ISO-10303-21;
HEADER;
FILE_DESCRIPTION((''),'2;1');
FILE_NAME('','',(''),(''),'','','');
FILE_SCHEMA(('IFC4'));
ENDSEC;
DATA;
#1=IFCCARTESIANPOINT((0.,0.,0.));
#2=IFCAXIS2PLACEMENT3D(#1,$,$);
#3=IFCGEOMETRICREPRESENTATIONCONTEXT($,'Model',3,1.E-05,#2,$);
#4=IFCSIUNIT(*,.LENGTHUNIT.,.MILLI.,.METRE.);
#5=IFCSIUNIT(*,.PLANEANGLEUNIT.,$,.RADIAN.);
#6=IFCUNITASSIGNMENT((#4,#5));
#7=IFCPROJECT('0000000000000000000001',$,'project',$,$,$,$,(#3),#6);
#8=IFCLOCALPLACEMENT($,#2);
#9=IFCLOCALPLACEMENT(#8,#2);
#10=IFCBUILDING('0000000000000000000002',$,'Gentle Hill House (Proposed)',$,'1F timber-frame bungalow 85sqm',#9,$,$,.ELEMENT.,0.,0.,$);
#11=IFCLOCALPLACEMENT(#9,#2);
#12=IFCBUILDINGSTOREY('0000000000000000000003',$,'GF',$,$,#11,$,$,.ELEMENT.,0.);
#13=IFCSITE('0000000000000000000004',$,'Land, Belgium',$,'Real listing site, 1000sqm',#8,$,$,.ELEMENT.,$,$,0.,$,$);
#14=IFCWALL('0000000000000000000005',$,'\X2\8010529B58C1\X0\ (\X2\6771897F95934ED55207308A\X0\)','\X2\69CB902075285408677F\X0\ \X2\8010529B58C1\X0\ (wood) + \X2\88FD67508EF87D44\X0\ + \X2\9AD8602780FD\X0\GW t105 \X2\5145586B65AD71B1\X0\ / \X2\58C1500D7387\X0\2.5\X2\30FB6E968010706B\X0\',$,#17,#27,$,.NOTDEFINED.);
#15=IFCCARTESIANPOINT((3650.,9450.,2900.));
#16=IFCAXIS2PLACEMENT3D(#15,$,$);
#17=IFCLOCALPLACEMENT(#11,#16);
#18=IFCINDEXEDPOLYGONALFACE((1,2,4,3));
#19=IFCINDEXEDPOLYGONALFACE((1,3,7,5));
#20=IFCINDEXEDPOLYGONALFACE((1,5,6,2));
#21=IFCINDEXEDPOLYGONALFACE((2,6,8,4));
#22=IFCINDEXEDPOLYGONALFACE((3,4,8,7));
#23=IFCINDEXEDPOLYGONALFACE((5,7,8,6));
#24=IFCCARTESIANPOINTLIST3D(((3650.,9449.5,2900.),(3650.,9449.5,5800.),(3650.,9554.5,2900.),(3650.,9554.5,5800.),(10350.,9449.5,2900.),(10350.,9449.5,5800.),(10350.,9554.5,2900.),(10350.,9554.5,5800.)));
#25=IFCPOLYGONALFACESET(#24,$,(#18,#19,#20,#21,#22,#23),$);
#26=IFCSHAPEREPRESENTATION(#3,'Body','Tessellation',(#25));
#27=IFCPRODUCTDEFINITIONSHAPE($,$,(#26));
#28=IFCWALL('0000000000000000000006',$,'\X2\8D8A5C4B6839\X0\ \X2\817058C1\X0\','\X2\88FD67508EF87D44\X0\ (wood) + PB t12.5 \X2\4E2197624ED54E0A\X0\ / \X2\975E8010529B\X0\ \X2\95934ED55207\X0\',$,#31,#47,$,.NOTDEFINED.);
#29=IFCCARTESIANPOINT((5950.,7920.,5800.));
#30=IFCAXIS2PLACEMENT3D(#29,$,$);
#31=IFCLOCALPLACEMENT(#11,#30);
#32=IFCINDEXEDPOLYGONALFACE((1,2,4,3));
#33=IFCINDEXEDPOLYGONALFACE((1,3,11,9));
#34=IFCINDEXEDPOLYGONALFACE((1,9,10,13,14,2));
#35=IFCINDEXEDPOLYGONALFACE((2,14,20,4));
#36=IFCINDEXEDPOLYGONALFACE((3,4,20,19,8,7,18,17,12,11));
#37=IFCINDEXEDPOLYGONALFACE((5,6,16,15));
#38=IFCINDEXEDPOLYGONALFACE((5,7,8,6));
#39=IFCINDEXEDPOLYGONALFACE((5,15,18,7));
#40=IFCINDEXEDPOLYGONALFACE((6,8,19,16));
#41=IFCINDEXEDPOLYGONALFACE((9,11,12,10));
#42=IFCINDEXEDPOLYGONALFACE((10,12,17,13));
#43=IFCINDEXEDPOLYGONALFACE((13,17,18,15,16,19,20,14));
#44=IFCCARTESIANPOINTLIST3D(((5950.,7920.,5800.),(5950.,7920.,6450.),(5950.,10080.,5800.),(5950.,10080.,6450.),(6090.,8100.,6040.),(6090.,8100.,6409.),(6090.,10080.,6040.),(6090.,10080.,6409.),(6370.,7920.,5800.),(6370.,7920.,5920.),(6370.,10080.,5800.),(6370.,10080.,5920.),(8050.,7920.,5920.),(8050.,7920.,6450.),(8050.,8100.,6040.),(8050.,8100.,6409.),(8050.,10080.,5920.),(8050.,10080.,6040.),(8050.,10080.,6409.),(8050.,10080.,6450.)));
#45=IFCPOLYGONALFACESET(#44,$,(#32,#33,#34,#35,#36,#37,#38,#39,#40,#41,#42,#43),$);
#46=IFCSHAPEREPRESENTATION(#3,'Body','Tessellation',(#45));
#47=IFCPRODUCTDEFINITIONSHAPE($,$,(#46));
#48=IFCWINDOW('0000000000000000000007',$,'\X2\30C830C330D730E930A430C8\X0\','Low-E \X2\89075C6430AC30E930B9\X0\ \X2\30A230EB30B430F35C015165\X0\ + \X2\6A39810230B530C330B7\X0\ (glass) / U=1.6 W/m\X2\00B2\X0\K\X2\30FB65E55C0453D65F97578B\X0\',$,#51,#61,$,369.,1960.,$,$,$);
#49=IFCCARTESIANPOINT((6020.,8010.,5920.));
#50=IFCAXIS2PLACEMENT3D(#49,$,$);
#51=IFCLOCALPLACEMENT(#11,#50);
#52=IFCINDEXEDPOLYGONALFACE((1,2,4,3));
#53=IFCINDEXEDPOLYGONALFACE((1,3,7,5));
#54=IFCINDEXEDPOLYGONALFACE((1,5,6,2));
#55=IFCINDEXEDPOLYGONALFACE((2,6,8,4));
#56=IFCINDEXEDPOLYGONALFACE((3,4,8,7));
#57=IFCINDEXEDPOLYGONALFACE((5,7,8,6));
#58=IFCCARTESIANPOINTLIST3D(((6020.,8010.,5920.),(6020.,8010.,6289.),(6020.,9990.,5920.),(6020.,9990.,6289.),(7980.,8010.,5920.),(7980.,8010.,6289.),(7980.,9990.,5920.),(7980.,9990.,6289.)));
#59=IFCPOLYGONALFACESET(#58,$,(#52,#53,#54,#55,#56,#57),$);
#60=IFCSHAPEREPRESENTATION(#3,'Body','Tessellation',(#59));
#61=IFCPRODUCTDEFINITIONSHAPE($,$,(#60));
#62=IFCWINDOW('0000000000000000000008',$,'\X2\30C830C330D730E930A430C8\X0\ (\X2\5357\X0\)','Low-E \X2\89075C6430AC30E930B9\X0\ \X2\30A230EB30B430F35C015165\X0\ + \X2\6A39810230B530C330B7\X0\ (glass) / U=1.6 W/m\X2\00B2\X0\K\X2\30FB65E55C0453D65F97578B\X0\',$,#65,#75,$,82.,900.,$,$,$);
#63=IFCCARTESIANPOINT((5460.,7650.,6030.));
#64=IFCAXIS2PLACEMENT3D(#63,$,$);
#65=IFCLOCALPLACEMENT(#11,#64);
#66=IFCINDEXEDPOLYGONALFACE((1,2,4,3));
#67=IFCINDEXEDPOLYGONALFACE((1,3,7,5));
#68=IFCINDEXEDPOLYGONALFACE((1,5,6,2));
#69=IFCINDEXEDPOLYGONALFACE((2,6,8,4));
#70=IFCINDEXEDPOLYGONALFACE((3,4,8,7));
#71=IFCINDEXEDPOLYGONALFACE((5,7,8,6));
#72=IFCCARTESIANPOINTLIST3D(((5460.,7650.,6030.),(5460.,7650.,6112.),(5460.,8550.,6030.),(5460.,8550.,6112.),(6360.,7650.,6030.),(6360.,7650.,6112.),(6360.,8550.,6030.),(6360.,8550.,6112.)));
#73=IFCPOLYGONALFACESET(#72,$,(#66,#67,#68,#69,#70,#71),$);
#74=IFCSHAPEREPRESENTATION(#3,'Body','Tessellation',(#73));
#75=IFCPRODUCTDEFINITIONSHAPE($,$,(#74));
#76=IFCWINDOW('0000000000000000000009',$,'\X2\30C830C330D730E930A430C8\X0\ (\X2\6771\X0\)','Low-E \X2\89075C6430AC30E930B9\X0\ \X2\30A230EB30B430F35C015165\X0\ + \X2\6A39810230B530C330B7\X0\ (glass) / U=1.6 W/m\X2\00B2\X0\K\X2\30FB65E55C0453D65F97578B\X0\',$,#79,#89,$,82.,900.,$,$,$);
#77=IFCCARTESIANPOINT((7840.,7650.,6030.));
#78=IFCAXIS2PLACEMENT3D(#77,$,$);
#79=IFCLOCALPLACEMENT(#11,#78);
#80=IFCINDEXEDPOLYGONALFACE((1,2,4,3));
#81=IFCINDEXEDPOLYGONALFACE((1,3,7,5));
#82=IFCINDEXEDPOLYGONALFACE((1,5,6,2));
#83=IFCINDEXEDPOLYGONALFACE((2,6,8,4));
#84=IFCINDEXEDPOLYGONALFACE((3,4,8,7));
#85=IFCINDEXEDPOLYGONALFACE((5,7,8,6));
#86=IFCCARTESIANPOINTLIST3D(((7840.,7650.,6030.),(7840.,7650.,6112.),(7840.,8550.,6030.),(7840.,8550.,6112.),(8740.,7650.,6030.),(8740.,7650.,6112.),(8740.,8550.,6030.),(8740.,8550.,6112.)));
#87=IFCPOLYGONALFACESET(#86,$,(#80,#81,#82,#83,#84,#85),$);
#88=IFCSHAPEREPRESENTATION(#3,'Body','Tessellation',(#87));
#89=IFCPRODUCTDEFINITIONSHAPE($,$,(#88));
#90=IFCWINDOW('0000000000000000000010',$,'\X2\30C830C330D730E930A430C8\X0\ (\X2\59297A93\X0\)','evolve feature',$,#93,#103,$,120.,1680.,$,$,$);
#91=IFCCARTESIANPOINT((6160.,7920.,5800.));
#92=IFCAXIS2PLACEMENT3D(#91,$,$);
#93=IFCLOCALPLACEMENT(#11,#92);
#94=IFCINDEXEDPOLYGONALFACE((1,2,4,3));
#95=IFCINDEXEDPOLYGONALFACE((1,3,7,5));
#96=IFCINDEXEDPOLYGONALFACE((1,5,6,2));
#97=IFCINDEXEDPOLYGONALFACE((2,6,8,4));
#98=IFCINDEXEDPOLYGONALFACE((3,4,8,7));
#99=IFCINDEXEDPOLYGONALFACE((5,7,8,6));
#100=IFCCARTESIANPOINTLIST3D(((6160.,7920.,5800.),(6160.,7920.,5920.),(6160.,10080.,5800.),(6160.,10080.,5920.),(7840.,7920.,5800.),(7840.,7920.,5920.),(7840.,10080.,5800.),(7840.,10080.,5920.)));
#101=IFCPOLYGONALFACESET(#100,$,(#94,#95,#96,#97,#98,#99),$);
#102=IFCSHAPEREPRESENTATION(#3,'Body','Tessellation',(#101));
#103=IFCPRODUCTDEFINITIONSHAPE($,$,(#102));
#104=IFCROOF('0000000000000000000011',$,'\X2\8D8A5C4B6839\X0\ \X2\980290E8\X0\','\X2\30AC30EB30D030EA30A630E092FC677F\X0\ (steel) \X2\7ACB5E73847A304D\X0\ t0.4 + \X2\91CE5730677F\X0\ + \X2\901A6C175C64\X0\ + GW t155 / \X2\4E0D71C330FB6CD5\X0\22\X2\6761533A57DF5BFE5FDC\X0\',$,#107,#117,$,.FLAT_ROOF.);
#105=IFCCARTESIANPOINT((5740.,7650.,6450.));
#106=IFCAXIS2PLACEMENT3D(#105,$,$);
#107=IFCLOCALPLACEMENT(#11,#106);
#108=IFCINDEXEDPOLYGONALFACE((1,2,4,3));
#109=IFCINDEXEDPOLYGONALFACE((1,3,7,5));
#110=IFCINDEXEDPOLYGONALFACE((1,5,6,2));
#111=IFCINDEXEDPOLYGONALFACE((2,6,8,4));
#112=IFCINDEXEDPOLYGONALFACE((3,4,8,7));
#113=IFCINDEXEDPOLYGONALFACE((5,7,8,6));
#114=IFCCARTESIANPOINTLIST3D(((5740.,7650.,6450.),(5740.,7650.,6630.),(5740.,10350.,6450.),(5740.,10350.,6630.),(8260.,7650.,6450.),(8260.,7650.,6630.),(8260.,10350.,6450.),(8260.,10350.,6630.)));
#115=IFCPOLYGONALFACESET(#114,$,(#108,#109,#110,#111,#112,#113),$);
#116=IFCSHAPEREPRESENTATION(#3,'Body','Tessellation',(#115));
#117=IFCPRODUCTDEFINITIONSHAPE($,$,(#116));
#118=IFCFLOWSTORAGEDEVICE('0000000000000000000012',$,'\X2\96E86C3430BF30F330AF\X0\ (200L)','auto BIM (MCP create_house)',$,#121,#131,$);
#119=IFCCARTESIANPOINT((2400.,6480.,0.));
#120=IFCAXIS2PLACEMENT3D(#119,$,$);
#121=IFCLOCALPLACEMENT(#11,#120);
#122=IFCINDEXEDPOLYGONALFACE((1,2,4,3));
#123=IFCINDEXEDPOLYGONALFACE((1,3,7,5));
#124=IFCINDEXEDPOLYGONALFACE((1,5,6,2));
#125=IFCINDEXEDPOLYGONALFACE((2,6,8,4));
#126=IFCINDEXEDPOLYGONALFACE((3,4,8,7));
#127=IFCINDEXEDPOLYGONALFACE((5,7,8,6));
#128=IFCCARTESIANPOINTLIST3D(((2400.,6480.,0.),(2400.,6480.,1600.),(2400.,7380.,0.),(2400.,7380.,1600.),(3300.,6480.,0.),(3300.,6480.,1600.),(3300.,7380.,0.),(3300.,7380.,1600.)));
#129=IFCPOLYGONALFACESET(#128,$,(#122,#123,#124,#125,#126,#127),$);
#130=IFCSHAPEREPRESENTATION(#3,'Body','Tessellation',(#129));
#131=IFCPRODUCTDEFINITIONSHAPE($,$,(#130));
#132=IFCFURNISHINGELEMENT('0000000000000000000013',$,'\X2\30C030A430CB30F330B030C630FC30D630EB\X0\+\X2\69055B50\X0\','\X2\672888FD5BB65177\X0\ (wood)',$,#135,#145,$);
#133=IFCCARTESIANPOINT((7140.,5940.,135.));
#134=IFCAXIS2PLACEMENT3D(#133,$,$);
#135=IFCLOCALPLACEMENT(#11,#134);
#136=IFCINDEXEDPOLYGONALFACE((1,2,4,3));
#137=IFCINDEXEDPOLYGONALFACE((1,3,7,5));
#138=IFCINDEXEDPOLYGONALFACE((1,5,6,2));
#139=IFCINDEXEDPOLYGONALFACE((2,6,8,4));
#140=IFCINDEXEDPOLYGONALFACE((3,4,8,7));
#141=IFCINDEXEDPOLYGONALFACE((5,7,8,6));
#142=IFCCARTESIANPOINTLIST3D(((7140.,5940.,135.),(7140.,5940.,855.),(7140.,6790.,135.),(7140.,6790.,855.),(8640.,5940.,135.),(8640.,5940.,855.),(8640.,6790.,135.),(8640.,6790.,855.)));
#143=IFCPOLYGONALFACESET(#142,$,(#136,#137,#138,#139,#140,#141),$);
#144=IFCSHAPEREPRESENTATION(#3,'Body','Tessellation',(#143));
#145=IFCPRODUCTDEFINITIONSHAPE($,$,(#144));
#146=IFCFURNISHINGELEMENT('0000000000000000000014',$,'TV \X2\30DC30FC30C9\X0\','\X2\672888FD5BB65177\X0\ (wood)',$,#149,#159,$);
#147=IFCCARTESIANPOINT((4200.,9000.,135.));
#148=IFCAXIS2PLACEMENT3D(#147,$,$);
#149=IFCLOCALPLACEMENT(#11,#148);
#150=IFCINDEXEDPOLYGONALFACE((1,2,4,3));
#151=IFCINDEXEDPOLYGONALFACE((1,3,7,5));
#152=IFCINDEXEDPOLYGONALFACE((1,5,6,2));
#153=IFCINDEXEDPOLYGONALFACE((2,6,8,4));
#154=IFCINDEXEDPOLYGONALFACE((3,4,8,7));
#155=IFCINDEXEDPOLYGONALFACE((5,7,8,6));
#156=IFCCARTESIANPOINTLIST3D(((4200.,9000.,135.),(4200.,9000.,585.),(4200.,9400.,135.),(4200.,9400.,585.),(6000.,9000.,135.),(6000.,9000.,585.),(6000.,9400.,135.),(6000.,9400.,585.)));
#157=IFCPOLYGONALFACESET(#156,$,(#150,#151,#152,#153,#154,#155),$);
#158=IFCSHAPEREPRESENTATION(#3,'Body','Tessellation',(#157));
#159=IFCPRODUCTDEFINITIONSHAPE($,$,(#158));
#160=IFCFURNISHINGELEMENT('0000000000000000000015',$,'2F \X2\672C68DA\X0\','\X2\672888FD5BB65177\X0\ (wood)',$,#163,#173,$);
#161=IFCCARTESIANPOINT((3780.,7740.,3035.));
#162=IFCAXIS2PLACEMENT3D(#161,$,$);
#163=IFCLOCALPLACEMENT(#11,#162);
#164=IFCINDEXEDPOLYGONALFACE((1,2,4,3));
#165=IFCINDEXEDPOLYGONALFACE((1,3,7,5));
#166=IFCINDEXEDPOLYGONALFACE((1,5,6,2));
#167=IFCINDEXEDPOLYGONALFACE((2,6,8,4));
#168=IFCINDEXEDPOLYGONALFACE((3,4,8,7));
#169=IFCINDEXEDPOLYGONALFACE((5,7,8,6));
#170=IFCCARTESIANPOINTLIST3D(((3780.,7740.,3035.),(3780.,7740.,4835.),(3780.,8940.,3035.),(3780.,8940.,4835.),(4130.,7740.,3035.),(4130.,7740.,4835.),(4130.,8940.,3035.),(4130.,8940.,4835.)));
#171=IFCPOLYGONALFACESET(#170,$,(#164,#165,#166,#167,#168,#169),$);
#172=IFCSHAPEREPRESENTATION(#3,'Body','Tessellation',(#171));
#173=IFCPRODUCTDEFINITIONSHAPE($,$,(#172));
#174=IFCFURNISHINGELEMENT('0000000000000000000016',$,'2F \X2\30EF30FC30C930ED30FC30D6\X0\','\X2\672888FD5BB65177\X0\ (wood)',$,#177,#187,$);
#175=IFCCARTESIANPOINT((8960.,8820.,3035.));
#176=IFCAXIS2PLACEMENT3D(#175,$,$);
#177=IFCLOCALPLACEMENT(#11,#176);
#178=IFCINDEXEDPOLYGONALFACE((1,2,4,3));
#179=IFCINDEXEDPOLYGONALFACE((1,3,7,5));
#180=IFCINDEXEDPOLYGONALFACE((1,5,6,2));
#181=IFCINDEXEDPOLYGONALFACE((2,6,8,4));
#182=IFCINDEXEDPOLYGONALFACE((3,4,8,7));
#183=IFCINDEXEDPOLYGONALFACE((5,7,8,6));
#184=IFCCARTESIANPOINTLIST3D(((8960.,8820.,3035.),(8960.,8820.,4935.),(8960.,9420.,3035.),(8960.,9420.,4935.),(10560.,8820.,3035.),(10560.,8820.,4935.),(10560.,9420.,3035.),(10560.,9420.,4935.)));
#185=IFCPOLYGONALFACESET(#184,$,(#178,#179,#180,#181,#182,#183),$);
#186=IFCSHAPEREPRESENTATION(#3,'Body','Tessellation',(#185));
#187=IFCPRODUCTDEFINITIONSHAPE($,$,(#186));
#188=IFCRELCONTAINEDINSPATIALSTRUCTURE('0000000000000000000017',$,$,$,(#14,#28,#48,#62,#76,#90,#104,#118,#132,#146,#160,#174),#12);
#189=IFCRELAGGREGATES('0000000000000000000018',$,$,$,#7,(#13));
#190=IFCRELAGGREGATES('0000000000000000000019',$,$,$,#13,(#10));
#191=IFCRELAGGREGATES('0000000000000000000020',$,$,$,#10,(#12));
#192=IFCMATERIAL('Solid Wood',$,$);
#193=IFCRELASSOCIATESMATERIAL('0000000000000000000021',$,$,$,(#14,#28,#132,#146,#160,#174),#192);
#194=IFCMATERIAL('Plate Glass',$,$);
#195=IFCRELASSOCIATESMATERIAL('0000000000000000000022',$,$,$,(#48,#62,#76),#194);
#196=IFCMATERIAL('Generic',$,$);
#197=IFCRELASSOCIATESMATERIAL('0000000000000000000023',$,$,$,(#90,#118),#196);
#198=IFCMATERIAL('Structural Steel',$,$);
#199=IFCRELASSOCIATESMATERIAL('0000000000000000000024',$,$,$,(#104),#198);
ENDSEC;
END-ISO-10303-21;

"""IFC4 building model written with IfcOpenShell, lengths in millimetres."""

from ifc_helpers import new_model, si_unit, frame, frame_2d, origin, place, context, project, spatial, rectangle, extrude, material, element, fill, save


model = new_model("IFC4")

# Units and contexts
model_context = context("Model", 3, precision=1e-05, world=origin())
ifc_project = project(units=[si_unit("LENGTHUNIT", "METRE", prefix="MILLI"), si_unit("PLANEANGLEUNIT", "RADIAN")], contexts=[model_context])

# Site, building, storey
site_placement = place(None, origin())
site = spatial("IfcSite", under=ifc_project, at=site_placement, Name="Land, Belgium", ObjectType="Real listing site, 1000sqm", CompositionType="ELEMENT", RefElevation=0.0)
building_placement = place(site_placement, origin())
building = spatial("IfcBuilding", under=site, at=building_placement, Name="Gentle Hill House (Proposed)", ObjectType="1F timber-frame bungalow 85sqm", CompositionType="ELEMENT", ElevationOfRefHeight=0.0, ElevationOfTerrain=0.0)
storey_placement = place(building_placement, origin())
storey = spatial("IfcBuildingStorey", under=building, at=storey_placement, Name="GF", CompositionType="ELEMENT", Elevation=0.0)

# Wall
ifc_material_1 = material(Name="Solid Wood")
wall_1_placement = place(storey_placement, frame((3650.0, 9450.0, 2900.0)))
element("IfcWall", 1, at=wall_1_placement, inside=storey, material=ifc_material_1, Name="耐力壁 (東西間仕切り)", Description="構造用合板 耐力壁 (wood) + 製材軸組 + 高性能GW t105 充填断熱 / 壁倍率2.5・準耐火", PredefinedType="NOTDEFINED", context=model_context, shape_type="SweptSolid", body=[
    extrude(rectangle(XDim=6700.0, YDim=105.0, at=frame_2d((3350.0, 52.0))), frame((3650.0, 9450.0, 2900.0)), (0.0, 0.0, 1.0), 2900.0),
])

# Wall, openings, windows
wall_2_placement = place(storey_placement, frame((5950.0, 7920.0, 5800.0)))
wall_2 = element("IfcWall", 2, at=wall_2_placement, inside=storey, material=ifc_material_1, Name="越屋根 腰壁", Description="製材軸組 (wood) + PB t12.5 両面仕上 / 非耐力 間仕切", PredefinedType="NOTDEFINED", context=model_context, shape_type="SweptSolid", body=[
    extrude(rectangle(XDim=2100.0, YDim=2160.0, at=frame_2d((1050.0, 1080.0))), frame((5950.0, 7920.0, 5800.0)), (0.0, 0.0, 1.0), 650.0),
])
opening_1_placement = place(storey_placement, frame((6020.0, 8010.0, 5920.0)))
opening_1 = element("IfcOpeningElement", 3, at=opening_1_placement, cuts=wall_2, PredefinedType="NOTDEFINED", context=model_context, shape_type="SweptSolid", body=[
    extrude(rectangle(XDim=1960.0, YDim=1980.0, at=frame_2d((980.0, 990.0))), frame((6020.0, 8010.0, 5920.0)), (0.0, 0.0, 1.0), 369.0),
])
opening_2_placement = place(storey_placement, frame((5460.0, 7650.0, 6030.0)))
opening_2 = element("IfcOpeningElement", 4, at=opening_2_placement, cuts=wall_2, PredefinedType="NOTDEFINED", context=model_context, shape_type="SweptSolid", body=[
    extrude(rectangle(XDim=900.0, YDim=900.0, at=frame_2d((450.0, 450.0))), frame((5460.0, 7650.0, 6030.0)), (0.0, 0.0, 1.0), 82.0),
])
opening_3_placement = place(storey_placement, frame((7840.0, 7650.0, 6030.0)))
opening_3 = element("IfcOpeningElement", 5, at=opening_3_placement, cuts=wall_2, PredefinedType="NOTDEFINED", context=model_context, shape_type="SweptSolid", body=[
    extrude(rectangle(XDim=900.0, YDim=900.0, at=frame_2d((450.0, 450.0))), frame((7840.0, 7650.0, 6030.0)), (0.0, 0.0, 1.0), 82.0),
])
opening_4_placement = place(storey_placement, frame((6160.0, 7920.0, 5800.0)))
opening_4 = element("IfcOpeningElement", 6, at=opening_4_placement, cuts=wall_2, PredefinedType="NOTDEFINED", context=model_context, shape_type="SweptSolid", body=[
    extrude(rectangle(XDim=1680.0, YDim=2160.0, at=frame_2d((840.0, 1080.0))), frame((6160.0, 7920.0, 5800.0)), (0.0, 0.0, 1.0), 120.0),
])
ifc_material_2 = material(Name="Plate Glass")
window_1_placement = place(storey_placement, frame((6020.0, 8010.0, 5920.0)))
window_1 = element("IfcWindow", 7, at=window_1_placement, inside=storey, material=ifc_material_2, Name="トップライト", Description="Low-E 複層ガラス アルゴン封入 + 樹脂サッシ (glass) / U=1.6 W/m²K・日射取得型", OverallHeight=369.0, OverallWidth=1960.0, context=model_context, shape_type="SweptSolid", body=[
    extrude(rectangle(XDim=1960.0, YDim=1980.0, at=frame_2d((980.0, 990.0))), frame((6020.0, 8010.0, 5920.0)), (0.0, 0.0, 1.0), 369.0),
])
fill(opening_1, window_1)
window_2_placement = place(storey_placement, frame((5460.0, 7650.0, 6030.0)))
window_2 = element("IfcWindow", 8, at=window_2_placement, inside=storey, material=ifc_material_2, Name="トップライト (南)", Description="Low-E 複層ガラス アルゴン封入 + 樹脂サッシ (glass) / U=1.6 W/m²K・日射取得型", OverallHeight=82.0, OverallWidth=900.0, context=model_context, shape_type="SweptSolid", body=[
    extrude(rectangle(XDim=900.0, YDim=900.0, at=frame_2d((450.0, 450.0))), frame((5460.0, 7650.0, 6030.0)), (0.0, 0.0, 1.0), 82.0),
])
fill(opening_2, window_2)
window_3_placement = place(storey_placement, frame((7840.0, 7650.0, 6030.0)))
window_3 = element("IfcWindow", 9, at=window_3_placement, inside=storey, material=ifc_material_2, Name="トップライト (東)", Description="Low-E 複層ガラス アルゴン封入 + 樹脂サッシ (glass) / U=1.6 W/m²K・日射取得型", OverallHeight=82.0, OverallWidth=900.0, context=model_context, shape_type="SweptSolid", body=[
    extrude(rectangle(XDim=900.0, YDim=900.0, at=frame_2d((450.0, 450.0))), frame((7840.0, 7650.0, 6030.0)), (0.0, 0.0, 1.0), 82.0),
])
fill(opening_3, window_3)
ifc_material_3 = material(Name="Generic")
window_4_placement = place(storey_placement, frame((6160.0, 7920.0, 5800.0)))
window_4 = element("IfcWindow", 10, at=window_4_placement, inside=storey, material=ifc_material_3, Name="トップライト (天窓)", Description="evolve feature", OverallHeight=120.0, OverallWidth=1680.0, context=model_context, shape_type="SweptSolid", body=[
    extrude(rectangle(XDim=1680.0, YDim=2160.0, at=frame_2d((840.0, 1080.0))), frame((6160.0, 7920.0, 5800.0)), (0.0, 0.0, 1.0), 120.0),
])
fill(opening_4, window_4)

# Roof
ifc_material_4 = material(Name="Structural Steel")
roof_placement = place(storey_placement, frame((5740.0, 7650.0, 6450.0)))
element("IfcRoof", 11, at=roof_placement, inside=storey, material=ifc_material_4, Name="越屋根 頂部", Description="ガルバリウム鋼板 (steel) 立平葺き t0.4 + 野地板 + 通気層 + GW t155 / 不燃・法22条区域対応", PredefinedType="FLAT_ROOF", context=model_context, shape_type="SweptSolid", body=[
    extrude(rectangle(XDim=2520.0, YDim=2700.0, at=frame_2d((1260.0, 1350.0))), frame((5740.0, 7650.0, 6450.0)), (0.0, 0.0, 1.0), 180.0),
])

# Flow storage device
flow_storage_device_placement = place(storey_placement, frame((2400.0, 6480.0, 0.0)))
element("IfcFlowStorageDevice", 12, at=flow_storage_device_placement, inside=storey, material=ifc_material_3, Name="雨水タンク (200L)", Description="auto BIM (MCP create_house)", context=model_context, shape_type="SweptSolid", body=[
    extrude(rectangle(XDim=900.0, YDim=900.0, at=frame_2d((450.0, 450.0))), frame((2400.0, 6480.0, 0.0)), (0.0, 0.0, 1.0), 1600.0),
])

# Furnishing elements
furnishing_1_placement = place(storey_placement, frame((7140.0, 5940.0, 135.0)))
element("IfcFurnishingElement", 13, at=furnishing_1_placement, inside=storey, material=ifc_material_1, Name="ダイニングテーブル+椅子", Description="木製家具 (wood)", context=model_context, shape_type="SweptSolid", body=[
    extrude(rectangle(XDim=1500.0, YDim=850.0, at=frame_2d((750.0, 425.0))), frame((7140.0, 5940.0, 135.0)), (0.0, 0.0, 1.0), 720.0),
])
furnishing_2_placement = place(storey_placement, frame((4200.0, 9000.0, 135.0)))
element("IfcFurnishingElement", 14, at=furnishing_2_placement, inside=storey, material=ifc_material_1, Name="TV ボード", Description="木製家具 (wood)", context=model_context, shape_type="SweptSolid", body=[
    extrude(rectangle(XDim=1800.0, YDim=400.0, at=frame_2d((900.0, 200.0))), frame((4200.0, 9000.0, 135.0)), (0.0, 0.0, 1.0), 450.0),
])
furnishing_3_placement = place(storey_placement, frame((3780.0, 7740.0, 3035.0)))
element("IfcFurnishingElement", 15, at=furnishing_3_placement, inside=storey, material=ifc_material_1, Name="2F 本棚", Description="木製家具 (wood)", context=model_context, shape_type="SweptSolid", body=[
    extrude(rectangle(XDim=350.0, YDim=1200.0, at=frame_2d((175.0, 600.0))), frame((3780.0, 7740.0, 3035.0)), (0.0, 0.0, 1.0), 1800.0),
])
furnishing_4_placement = place(storey_placement, frame((8960.0, 8820.0, 3035.0)))
element("IfcFurnishingElement", 16, at=furnishing_4_placement, inside=storey, material=ifc_material_1, Name="2F ワードローブ", Description="木製家具 (wood)", context=model_context, shape_type="SweptSolid", body=[
    extrude(rectangle(XDim=1600.0, YDim=600.0, at=frame_2d((800.0, 300.0))), frame((8960.0, 8820.0, 3035.0)), (0.0, 0.0, 1.0), 1900.0),
])

save(model, "model.ifc")
